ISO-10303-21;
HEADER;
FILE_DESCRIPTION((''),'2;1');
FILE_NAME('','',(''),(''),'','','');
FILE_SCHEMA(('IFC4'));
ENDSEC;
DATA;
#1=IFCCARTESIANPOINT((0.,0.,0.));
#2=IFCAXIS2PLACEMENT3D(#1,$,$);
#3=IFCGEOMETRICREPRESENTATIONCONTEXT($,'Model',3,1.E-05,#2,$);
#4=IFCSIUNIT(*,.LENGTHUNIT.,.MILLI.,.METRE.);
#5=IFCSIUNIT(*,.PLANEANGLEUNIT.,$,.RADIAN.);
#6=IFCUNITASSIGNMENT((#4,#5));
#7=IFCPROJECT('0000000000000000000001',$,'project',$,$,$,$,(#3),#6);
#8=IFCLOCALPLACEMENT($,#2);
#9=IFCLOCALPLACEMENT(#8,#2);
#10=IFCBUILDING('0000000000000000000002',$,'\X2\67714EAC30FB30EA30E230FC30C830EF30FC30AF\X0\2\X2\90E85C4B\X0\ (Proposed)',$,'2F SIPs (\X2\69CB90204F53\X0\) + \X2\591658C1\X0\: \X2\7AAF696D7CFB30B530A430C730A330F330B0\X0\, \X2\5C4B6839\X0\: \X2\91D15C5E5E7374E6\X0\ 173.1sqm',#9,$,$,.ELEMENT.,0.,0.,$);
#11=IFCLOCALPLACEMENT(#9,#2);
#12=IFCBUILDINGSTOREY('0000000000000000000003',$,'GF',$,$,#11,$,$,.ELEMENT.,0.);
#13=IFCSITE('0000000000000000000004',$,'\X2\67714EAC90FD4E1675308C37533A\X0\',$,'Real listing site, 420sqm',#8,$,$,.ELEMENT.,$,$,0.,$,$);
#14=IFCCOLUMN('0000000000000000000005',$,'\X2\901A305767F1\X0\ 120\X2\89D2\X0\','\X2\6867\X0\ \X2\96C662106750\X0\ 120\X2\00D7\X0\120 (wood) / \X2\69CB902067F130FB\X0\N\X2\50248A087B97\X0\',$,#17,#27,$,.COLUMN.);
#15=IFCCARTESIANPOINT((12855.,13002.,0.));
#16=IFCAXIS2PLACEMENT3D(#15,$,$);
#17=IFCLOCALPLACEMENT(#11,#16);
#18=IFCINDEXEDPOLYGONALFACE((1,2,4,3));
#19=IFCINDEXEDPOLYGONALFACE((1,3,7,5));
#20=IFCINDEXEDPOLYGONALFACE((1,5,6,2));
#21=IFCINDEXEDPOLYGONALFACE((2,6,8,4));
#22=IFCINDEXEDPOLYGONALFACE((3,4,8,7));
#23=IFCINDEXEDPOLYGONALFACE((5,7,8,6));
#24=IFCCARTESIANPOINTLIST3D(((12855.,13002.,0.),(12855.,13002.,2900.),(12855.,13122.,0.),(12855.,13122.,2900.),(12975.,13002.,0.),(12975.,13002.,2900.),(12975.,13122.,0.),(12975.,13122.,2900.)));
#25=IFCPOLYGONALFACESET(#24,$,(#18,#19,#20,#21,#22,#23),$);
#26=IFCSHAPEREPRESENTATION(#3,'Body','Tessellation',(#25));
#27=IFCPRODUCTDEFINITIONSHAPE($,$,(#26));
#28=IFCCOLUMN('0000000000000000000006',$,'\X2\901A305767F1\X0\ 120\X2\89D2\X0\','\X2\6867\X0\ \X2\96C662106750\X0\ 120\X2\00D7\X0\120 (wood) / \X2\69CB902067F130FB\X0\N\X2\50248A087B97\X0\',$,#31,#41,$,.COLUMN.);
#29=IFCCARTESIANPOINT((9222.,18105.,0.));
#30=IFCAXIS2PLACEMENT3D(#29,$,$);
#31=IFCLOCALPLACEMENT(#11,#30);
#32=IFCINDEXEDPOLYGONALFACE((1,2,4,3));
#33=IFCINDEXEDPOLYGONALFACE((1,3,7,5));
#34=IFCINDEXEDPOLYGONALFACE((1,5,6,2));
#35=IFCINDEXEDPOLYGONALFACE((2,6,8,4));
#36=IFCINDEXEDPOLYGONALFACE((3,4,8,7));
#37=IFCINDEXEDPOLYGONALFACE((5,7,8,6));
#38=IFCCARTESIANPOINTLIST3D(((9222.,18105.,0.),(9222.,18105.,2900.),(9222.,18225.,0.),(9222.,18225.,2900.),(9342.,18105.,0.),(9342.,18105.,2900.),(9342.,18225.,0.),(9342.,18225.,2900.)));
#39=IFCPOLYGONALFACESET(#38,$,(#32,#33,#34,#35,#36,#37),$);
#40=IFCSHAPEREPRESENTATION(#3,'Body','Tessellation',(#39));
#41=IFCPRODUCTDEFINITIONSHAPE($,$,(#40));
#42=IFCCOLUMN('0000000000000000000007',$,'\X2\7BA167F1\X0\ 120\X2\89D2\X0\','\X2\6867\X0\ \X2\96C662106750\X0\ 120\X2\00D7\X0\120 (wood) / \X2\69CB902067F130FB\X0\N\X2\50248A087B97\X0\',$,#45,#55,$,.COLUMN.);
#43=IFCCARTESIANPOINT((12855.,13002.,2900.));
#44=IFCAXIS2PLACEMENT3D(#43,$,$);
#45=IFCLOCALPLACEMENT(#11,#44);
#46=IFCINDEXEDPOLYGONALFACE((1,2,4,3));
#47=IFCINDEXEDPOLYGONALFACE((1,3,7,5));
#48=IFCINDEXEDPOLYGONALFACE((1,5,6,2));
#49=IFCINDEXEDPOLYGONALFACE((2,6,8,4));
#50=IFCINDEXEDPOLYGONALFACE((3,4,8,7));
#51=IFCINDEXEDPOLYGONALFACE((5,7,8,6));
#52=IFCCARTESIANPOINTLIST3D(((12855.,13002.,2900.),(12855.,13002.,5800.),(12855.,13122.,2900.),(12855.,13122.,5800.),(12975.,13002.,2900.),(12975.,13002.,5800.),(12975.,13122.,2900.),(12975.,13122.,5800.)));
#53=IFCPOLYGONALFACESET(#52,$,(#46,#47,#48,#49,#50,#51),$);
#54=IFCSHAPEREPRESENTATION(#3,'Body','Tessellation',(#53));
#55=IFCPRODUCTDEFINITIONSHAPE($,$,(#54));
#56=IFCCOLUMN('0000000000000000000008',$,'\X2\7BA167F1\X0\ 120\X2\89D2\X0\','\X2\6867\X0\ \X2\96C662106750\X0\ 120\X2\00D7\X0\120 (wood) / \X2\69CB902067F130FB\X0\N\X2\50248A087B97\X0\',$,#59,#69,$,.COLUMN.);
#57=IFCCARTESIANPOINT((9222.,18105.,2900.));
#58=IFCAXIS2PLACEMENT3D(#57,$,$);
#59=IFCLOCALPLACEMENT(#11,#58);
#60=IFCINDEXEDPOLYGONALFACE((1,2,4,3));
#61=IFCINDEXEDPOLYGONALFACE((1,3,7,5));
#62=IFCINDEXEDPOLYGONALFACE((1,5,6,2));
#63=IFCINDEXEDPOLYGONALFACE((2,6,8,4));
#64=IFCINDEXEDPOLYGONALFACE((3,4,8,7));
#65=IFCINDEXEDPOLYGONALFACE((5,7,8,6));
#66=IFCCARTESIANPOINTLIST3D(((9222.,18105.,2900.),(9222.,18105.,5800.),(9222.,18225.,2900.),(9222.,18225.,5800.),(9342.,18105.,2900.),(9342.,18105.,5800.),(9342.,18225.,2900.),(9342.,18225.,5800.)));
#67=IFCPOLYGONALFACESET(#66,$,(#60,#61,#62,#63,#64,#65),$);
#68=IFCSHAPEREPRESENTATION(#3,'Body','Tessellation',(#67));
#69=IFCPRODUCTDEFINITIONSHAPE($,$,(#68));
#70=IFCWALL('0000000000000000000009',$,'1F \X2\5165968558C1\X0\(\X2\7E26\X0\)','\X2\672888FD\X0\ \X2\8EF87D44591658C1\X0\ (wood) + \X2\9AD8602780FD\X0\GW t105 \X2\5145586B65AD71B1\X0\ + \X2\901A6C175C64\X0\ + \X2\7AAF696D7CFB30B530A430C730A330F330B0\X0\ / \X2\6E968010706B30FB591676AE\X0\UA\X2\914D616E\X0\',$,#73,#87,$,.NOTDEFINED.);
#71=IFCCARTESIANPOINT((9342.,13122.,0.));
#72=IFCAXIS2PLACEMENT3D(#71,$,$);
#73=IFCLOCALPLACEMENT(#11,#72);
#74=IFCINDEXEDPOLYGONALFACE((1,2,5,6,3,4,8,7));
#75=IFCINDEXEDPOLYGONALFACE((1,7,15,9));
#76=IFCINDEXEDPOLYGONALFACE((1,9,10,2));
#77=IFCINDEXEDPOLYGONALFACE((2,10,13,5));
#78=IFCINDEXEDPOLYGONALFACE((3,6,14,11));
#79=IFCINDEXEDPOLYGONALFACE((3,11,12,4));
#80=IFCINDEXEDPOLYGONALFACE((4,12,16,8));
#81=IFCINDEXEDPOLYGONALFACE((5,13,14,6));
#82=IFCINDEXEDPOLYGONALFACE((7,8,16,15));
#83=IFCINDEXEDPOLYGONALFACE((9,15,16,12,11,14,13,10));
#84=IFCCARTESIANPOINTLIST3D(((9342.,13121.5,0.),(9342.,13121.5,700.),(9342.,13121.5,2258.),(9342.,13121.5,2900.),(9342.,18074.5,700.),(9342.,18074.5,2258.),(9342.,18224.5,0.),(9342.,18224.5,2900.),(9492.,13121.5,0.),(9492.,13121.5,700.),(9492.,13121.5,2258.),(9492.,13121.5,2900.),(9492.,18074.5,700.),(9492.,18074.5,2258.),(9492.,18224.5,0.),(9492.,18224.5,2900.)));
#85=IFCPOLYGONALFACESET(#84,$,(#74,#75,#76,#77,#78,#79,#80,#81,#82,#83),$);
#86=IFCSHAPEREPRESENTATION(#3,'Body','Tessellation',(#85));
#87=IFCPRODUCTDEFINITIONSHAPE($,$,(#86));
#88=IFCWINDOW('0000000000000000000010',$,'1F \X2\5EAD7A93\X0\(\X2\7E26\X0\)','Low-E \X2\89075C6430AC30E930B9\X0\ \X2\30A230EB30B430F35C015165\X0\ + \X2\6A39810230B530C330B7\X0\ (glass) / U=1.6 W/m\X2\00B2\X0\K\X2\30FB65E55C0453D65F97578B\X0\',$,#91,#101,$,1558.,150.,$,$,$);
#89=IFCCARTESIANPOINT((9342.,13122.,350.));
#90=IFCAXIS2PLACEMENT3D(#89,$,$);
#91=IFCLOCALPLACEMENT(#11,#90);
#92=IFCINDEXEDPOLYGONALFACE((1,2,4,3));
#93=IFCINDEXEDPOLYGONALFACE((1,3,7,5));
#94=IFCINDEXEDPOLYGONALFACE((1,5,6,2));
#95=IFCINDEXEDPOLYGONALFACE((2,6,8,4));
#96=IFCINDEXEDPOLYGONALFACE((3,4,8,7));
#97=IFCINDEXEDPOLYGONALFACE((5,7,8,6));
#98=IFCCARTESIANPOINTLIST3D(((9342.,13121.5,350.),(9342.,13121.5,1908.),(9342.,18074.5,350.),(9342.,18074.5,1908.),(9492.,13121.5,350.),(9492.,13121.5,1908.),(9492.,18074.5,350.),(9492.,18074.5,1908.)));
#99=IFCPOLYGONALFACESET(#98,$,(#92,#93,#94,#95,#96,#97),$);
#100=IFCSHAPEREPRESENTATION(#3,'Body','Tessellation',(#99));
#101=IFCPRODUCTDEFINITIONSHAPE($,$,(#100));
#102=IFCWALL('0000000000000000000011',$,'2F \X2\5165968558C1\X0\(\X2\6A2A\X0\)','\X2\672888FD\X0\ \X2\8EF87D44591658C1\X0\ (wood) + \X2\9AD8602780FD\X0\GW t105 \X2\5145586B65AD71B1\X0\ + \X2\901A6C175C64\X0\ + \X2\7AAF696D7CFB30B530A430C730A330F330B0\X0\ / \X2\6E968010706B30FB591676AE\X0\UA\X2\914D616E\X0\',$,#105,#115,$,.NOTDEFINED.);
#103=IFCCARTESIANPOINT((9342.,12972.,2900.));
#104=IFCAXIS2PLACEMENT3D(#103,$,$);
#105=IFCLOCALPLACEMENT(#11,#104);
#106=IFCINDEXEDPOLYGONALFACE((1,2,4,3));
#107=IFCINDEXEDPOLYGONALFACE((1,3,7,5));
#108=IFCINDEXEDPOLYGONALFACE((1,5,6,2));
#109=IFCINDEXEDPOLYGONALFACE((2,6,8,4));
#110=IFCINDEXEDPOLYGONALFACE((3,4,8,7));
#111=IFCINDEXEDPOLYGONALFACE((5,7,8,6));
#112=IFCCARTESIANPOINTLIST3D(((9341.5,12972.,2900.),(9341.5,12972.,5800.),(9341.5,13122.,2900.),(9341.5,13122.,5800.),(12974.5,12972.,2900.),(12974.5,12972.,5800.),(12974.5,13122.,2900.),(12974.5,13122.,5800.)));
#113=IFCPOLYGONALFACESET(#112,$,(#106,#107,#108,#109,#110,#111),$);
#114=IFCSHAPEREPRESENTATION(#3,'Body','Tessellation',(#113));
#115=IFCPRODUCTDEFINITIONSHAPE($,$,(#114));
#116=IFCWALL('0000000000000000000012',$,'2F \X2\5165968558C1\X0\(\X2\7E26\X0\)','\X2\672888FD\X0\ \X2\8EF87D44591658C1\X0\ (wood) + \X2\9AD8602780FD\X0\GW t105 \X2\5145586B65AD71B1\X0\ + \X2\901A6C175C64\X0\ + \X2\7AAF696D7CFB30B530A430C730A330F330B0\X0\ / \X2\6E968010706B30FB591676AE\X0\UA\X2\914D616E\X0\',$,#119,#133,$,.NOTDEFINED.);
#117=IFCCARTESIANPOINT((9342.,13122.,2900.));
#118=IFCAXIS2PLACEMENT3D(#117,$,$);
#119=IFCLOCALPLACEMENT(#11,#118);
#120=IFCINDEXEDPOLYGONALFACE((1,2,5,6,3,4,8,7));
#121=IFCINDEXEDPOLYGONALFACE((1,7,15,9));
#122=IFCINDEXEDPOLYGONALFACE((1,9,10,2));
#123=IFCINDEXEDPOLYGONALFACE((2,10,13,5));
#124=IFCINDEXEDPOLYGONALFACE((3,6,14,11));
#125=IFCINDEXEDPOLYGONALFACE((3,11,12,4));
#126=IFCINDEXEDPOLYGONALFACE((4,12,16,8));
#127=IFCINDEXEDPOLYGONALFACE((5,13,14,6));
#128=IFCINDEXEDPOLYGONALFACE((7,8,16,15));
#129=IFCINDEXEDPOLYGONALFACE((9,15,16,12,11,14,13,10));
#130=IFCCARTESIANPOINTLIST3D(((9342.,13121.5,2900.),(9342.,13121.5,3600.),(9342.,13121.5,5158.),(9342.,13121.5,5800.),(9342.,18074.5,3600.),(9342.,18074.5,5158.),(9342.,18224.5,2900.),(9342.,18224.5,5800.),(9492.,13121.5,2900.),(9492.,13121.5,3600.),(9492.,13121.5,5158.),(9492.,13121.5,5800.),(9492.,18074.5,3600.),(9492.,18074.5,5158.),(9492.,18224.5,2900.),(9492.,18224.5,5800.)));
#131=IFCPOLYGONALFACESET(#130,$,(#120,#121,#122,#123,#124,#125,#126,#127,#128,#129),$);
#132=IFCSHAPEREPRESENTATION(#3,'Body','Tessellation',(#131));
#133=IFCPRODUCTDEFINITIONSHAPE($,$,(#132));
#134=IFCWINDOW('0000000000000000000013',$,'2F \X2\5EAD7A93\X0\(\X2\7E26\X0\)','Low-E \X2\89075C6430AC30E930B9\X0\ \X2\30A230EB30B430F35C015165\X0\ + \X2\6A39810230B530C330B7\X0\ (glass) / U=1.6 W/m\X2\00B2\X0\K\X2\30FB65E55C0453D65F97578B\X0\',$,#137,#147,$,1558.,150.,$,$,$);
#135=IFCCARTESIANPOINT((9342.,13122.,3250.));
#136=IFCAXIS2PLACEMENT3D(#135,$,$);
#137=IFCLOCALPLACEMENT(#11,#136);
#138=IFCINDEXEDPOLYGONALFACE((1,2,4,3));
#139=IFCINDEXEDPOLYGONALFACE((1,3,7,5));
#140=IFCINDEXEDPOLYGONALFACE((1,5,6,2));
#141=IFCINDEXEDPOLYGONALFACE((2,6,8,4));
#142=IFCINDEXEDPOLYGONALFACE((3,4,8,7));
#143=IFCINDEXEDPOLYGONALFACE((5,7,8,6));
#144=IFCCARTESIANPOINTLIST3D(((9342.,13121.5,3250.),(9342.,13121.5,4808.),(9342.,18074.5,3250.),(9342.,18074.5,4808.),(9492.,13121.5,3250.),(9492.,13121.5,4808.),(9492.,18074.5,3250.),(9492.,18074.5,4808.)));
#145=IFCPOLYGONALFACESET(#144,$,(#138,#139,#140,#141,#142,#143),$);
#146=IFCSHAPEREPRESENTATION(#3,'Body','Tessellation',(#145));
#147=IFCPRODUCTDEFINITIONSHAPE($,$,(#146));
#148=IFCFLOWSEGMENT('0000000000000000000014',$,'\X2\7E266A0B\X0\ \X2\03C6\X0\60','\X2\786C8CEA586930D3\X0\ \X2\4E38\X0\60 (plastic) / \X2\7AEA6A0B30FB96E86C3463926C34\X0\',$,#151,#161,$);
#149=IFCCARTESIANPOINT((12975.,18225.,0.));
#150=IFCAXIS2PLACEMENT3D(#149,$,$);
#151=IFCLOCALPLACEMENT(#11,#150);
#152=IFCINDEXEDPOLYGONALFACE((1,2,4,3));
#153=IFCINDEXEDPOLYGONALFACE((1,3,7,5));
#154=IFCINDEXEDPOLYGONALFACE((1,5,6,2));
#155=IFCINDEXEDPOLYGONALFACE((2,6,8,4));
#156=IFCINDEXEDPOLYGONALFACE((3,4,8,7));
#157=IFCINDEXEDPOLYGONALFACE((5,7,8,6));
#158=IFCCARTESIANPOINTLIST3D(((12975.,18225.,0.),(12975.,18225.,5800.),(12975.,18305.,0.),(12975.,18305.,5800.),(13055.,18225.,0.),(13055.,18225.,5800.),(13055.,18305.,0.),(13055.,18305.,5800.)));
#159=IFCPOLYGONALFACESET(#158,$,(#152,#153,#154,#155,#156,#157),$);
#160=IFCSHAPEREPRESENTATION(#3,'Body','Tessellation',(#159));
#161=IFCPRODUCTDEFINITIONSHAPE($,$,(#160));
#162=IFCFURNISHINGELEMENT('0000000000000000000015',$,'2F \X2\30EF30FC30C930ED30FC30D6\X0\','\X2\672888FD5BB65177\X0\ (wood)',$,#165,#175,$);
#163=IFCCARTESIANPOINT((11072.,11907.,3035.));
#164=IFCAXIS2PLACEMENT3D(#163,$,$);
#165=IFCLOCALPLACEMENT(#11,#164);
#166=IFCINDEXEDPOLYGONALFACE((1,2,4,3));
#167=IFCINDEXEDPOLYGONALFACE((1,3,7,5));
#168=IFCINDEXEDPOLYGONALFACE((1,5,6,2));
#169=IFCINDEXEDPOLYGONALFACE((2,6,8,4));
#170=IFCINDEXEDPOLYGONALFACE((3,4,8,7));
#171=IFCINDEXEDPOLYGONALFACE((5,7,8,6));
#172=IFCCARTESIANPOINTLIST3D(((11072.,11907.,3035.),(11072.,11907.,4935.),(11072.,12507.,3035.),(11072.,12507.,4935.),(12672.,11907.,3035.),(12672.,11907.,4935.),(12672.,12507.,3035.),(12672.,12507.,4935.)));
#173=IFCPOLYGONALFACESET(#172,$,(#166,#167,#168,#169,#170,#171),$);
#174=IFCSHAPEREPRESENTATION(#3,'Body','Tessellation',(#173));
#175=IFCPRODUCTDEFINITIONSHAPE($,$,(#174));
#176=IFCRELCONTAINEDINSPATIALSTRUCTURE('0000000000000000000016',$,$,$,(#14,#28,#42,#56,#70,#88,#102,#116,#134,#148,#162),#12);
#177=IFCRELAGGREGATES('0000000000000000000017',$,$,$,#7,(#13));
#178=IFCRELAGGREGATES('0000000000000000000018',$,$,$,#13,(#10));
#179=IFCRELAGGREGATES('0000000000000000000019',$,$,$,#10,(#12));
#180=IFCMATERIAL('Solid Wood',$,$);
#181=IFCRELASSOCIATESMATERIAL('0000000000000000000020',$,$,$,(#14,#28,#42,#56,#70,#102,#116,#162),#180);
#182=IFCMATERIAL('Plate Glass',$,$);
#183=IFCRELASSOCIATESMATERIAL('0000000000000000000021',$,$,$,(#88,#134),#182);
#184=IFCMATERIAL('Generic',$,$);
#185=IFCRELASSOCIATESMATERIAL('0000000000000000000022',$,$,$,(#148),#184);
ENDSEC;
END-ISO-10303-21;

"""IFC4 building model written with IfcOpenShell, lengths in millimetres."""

from ifc_helpers import new_model, si_unit, frame, frame_2d, origin, place, context, project, spatial, rectangle, extrude, material, element, fill, save


model = new_model("IFC4")

# Units and contexts
model_context = context("Model", 3, precision=1e-05, world=origin())
ifc_project = project(units=[si_unit("LENGTHUNIT", "METRE", prefix="MILLI"), si_unit("PLANEANGLEUNIT", "RADIAN")], contexts=[model_context])

# Site, building, storey
site_placement = place(None, origin())
site = spatial("IfcSite", under=ifc_project, at=site_placement, Name="東京都世田谷区", ObjectType="Real listing site, 420sqm", CompositionType="ELEMENT", RefElevation=0.0)
building_placement = place(site_placement, origin())
building = spatial("IfcBuilding", under=site, at=building_placement, Name="東京・リモートワーク2部屋 (Proposed)", ObjectType="2F SIPs (構造体) + 外壁: 窯業系サイディング, 屋根: 金属平瓦 173.1sqm", CompositionType="ELEMENT", ElevationOfRefHeight=0.0, ElevationOfTerrain=0.0)
storey_placement = place(building_placement, origin())
storey = spatial("IfcBuildingStorey", under=building, at=storey_placement, Name="GF", CompositionType="ELEMENT", Elevation=0.0)

# Columns
ifc_material_1 = material(Name="Solid Wood")
column_1_placement = place(storey_placement, frame((12855.0, 13002.0, 0.0)))
element("IfcColumn", 1, at=column_1_placement, inside=storey, material=ifc_material_1, Name="通し柱 120角", Description="桧 集成材 120×120 (wood) / 構造柱・N値計算", PredefinedType="COLUMN", context=model_context, shape_type="SweptSolid", body=[
    extrude(rectangle(XDim=120.0, YDim=120.0, at=frame_2d((60.0, 60.0))), frame((12855.0, 13002.0, 0.0)), (0.0, 0.0, 1.0), 2900.0),
])
column_2_placement = place(storey_placement, frame((9222.0, 18105.0, 0.0)))
element("IfcColumn", 2, at=column_2_placement, inside=storey, material=ifc_material_1, Name="通し柱 120角", Description="桧 集成材 120×120 (wood) / 構造柱・N値計算", PredefinedType="COLUMN", context=model_context, shape_type="SweptSolid", body=[
    extrude(rectangle(XDim=120.0, YDim=120.0, at=frame_2d((60.0, 60.0))), frame((9222.0, 18105.0, 0.0)), (0.0, 0.0, 1.0), 2900.0),
])
column_3_placement = place(storey_placement, frame((12855.0, 13002.0, 2900.0)))
element("IfcColumn", 3, at=column_3_placement, inside=storey, material=ifc_material_1, Name="管柱 120角", Description="桧 集成材 120×120 (wood) / 構造柱・N値計算", PredefinedType="COLUMN", context=model_context, shape_type="SweptSolid", body=[
    extrude(rectangle(XDim=120.0, YDim=120.0, at=frame_2d((60.0, 60.0))), frame((12855.0, 13002.0, 2900.0)), (0.0, 0.0, 1.0), 2900.0),
])
column_4_placement = place(storey_placement, frame((9222.0, 18105.0, 2900.0)))
element("IfcColumn", 4, at=column_4_placement, inside=storey, material=ifc_material_1, Name="管柱 120角", Description="桧 集成材 120×120 (wood) / 構造柱・N値計算", PredefinedType="COLUMN", context=model_context, shape_type="SweptSolid", body=[
    extrude(rectangle(XDim=120.0, YDim=120.0, at=frame_2d((60.0, 60.0))), frame((9222.0, 18105.0, 2900.0)), (0.0, 0.0, 1.0), 2900.0),
])

# Wall, opening, window
wall_1_placement = place(storey_placement, frame((9342.0, 13122.0, 0.0)))
wall_1 = element("IfcWall", 5, at=wall_1_placement, inside=storey, material=ifc_material_1, Name="1F 入隅壁(縦)", Description="木製 軸組外壁 (wood) + 高性能GW t105 充填断熱 + 通気層 + 窯業系サイディング / 準耐火・外皮UA配慮", PredefinedType="NOTDEFINED", context=model_context, shape_type="SweptSolid", body=[
    extrude(rectangle(XDim=150.0, YDim=5103.0, at=frame_2d((75.0, 2551.0))), frame((9342.0, 13122.0, 0.0)), (0.0, 0.0, 1.0), 2900.0),
])
opening_1_placement = place(storey_placement, frame((9342.0, 13122.0, 350.0)))
opening_1 = element("IfcOpeningElement", 6, at=opening_1_placement, cuts=wall_1, PredefinedType="NOTDEFINED", context=model_context, shape_type="SweptSolid", body=[
    extrude(rectangle(XDim=150.0, YDim=4953.0, at=frame_2d((75.0, 2476.0))), frame((9342.0, 13122.0, 350.0)), (0.0, 0.0, 1.0), 1558.0),
])
ifc_material_2 = material(Name="Plate Glass")
window_1_placement = place(storey_placement, frame((9342.0, 13122.0, 350.0)))
window_1 = element("IfcWindow", 7, at=window_1_placement, inside=storey, material=ifc_material_2, Name="1F 庭窓(縦)", Description="Low-E 複層ガラス アルゴン封入 + 樹脂サッシ (glass) / U=1.6 W/m²K・日射取得型", OverallHeight=1558.0, OverallWidth=150.0, context=model_context, shape_type="SweptSolid", body=[
    extrude(rectangle(XDim=150.0, YDim=4953.0, at=frame_2d((75.0, 2476.0))), frame((9342.0, 13122.0, 350.0)), (0.0, 0.0, 1.0), 1558.0),
])
fill(opening_1, window_1)

# Wall
wall_2_placement = place(storey_placement, frame((9342.0, 12972.0, 2900.0)))
element("IfcWall", 8, at=wall_2_placement, inside=storey, material=ifc_material_1, Name="2F 入隅壁(横)", Description="木製 軸組外壁 (wood) + 高性能GW t105 充填断熱 + 通気層 + 窯業系サイディング / 準耐火・外皮UA配慮", PredefinedType="NOTDEFINED", context=model_context, shape_type="SweptSolid", body=[
    extrude(rectangle(XDim=3633.0, YDim=150.0, at=frame_2d((1816.0, 75.0))), frame((9342.0, 12972.0, 2900.0)), (0.0, 0.0, 1.0), 2900.0),
])

# Wall, opening, window
wall_3_placement = place(storey_placement, frame((9342.0, 13122.0, 2900.0)))
wall_3 = element("IfcWall", 9, at=wall_3_placement, inside=storey, material=ifc_material_1, Name="2F 入隅壁(縦)", Description="木製 軸組外壁 (wood) + 高性能GW t105 充填断熱 + 通気層 + 窯業系サイディング / 準耐火・外皮UA配慮", PredefinedType="NOTDEFINED", context=model_context, shape_type="SweptSolid", body=[
    extrude(rectangle(XDim=150.0, YDim=5103.0, at=frame_2d((75.0, 2551.0))), frame((9342.0, 13122.0, 2900.0)), (0.0, 0.0, 1.0), 2900.0),
])
opening_2_placement = place(storey_placement, frame((9342.0, 13122.0, 3250.0)))
opening_2 = element("IfcOpeningElement", 10, at=opening_2_placement, cuts=wall_3, PredefinedType="NOTDEFINED", context=model_context, shape_type="SweptSolid", body=[
    extrude(rectangle(XDim=150.0, YDim=4953.0, at=frame_2d((75.0, 2476.0))), frame((9342.0, 13122.0, 3250.0)), (0.0, 0.0, 1.0), 1558.0),
])
window_2_placement = place(storey_placement, frame((9342.0, 13122.0, 3250.0)))
window_2 = element("IfcWindow", 11, at=window_2_placement, inside=storey, material=ifc_material_2, Name="2F 庭窓(縦)", Description="Low-E 複層ガラス アルゴン封入 + 樹脂サッシ (glass) / U=1.6 W/m²K・日射取得型", OverallHeight=1558.0, OverallWidth=150.0, context=model_context, shape_type="SweptSolid", body=[
    extrude(rectangle(XDim=150.0, YDim=4953.0, at=frame_2d((75.0, 2476.0))), frame((9342.0, 13122.0, 3250.0)), (0.0, 0.0, 1.0), 1558.0),
])
fill(opening_2, window_2)

# Flow segment
ifc_material_3 = material(Name="Generic")
flow_segment_placement = place(storey_placement, frame((12975.0, 18225.0, 0.0)))
element("IfcFlowSegment", 12, at=flow_segment_placement, inside=storey, material=ifc_material_3, Name="縦樋 φ60", Description="硬質塩ビ 丸60 (plastic) / 竪樋・雨水排水", context=model_context, shape_type="SweptSolid", body=[
    extrude(rectangle(XDim=80.0, YDim=80.0, at=frame_2d((40.0, 40.0))), frame((12975.0, 18225.0, 0.0)), (0.0, 0.0, 1.0), 5800.0),
])

# Furnishing element
furnishing_placement = place(storey_placement, frame((11072.0, 11907.0, 3035.0)))
element("IfcFurnishingElement", 13, at=furnishing_placement, inside=storey, material=ifc_material_1, Name="2F ワードローブ", Description="木製家具 (wood)", context=model_context, shape_type="SweptSolid", body=[
    extrude(rectangle(XDim=1600.0, YDim=600.0, at=frame_2d((800.0, 300.0))), frame((11072.0, 11907.0, 3035.0)), (0.0, 0.0, 1.0), 1900.0),
])

save(model, "model.ifc")
